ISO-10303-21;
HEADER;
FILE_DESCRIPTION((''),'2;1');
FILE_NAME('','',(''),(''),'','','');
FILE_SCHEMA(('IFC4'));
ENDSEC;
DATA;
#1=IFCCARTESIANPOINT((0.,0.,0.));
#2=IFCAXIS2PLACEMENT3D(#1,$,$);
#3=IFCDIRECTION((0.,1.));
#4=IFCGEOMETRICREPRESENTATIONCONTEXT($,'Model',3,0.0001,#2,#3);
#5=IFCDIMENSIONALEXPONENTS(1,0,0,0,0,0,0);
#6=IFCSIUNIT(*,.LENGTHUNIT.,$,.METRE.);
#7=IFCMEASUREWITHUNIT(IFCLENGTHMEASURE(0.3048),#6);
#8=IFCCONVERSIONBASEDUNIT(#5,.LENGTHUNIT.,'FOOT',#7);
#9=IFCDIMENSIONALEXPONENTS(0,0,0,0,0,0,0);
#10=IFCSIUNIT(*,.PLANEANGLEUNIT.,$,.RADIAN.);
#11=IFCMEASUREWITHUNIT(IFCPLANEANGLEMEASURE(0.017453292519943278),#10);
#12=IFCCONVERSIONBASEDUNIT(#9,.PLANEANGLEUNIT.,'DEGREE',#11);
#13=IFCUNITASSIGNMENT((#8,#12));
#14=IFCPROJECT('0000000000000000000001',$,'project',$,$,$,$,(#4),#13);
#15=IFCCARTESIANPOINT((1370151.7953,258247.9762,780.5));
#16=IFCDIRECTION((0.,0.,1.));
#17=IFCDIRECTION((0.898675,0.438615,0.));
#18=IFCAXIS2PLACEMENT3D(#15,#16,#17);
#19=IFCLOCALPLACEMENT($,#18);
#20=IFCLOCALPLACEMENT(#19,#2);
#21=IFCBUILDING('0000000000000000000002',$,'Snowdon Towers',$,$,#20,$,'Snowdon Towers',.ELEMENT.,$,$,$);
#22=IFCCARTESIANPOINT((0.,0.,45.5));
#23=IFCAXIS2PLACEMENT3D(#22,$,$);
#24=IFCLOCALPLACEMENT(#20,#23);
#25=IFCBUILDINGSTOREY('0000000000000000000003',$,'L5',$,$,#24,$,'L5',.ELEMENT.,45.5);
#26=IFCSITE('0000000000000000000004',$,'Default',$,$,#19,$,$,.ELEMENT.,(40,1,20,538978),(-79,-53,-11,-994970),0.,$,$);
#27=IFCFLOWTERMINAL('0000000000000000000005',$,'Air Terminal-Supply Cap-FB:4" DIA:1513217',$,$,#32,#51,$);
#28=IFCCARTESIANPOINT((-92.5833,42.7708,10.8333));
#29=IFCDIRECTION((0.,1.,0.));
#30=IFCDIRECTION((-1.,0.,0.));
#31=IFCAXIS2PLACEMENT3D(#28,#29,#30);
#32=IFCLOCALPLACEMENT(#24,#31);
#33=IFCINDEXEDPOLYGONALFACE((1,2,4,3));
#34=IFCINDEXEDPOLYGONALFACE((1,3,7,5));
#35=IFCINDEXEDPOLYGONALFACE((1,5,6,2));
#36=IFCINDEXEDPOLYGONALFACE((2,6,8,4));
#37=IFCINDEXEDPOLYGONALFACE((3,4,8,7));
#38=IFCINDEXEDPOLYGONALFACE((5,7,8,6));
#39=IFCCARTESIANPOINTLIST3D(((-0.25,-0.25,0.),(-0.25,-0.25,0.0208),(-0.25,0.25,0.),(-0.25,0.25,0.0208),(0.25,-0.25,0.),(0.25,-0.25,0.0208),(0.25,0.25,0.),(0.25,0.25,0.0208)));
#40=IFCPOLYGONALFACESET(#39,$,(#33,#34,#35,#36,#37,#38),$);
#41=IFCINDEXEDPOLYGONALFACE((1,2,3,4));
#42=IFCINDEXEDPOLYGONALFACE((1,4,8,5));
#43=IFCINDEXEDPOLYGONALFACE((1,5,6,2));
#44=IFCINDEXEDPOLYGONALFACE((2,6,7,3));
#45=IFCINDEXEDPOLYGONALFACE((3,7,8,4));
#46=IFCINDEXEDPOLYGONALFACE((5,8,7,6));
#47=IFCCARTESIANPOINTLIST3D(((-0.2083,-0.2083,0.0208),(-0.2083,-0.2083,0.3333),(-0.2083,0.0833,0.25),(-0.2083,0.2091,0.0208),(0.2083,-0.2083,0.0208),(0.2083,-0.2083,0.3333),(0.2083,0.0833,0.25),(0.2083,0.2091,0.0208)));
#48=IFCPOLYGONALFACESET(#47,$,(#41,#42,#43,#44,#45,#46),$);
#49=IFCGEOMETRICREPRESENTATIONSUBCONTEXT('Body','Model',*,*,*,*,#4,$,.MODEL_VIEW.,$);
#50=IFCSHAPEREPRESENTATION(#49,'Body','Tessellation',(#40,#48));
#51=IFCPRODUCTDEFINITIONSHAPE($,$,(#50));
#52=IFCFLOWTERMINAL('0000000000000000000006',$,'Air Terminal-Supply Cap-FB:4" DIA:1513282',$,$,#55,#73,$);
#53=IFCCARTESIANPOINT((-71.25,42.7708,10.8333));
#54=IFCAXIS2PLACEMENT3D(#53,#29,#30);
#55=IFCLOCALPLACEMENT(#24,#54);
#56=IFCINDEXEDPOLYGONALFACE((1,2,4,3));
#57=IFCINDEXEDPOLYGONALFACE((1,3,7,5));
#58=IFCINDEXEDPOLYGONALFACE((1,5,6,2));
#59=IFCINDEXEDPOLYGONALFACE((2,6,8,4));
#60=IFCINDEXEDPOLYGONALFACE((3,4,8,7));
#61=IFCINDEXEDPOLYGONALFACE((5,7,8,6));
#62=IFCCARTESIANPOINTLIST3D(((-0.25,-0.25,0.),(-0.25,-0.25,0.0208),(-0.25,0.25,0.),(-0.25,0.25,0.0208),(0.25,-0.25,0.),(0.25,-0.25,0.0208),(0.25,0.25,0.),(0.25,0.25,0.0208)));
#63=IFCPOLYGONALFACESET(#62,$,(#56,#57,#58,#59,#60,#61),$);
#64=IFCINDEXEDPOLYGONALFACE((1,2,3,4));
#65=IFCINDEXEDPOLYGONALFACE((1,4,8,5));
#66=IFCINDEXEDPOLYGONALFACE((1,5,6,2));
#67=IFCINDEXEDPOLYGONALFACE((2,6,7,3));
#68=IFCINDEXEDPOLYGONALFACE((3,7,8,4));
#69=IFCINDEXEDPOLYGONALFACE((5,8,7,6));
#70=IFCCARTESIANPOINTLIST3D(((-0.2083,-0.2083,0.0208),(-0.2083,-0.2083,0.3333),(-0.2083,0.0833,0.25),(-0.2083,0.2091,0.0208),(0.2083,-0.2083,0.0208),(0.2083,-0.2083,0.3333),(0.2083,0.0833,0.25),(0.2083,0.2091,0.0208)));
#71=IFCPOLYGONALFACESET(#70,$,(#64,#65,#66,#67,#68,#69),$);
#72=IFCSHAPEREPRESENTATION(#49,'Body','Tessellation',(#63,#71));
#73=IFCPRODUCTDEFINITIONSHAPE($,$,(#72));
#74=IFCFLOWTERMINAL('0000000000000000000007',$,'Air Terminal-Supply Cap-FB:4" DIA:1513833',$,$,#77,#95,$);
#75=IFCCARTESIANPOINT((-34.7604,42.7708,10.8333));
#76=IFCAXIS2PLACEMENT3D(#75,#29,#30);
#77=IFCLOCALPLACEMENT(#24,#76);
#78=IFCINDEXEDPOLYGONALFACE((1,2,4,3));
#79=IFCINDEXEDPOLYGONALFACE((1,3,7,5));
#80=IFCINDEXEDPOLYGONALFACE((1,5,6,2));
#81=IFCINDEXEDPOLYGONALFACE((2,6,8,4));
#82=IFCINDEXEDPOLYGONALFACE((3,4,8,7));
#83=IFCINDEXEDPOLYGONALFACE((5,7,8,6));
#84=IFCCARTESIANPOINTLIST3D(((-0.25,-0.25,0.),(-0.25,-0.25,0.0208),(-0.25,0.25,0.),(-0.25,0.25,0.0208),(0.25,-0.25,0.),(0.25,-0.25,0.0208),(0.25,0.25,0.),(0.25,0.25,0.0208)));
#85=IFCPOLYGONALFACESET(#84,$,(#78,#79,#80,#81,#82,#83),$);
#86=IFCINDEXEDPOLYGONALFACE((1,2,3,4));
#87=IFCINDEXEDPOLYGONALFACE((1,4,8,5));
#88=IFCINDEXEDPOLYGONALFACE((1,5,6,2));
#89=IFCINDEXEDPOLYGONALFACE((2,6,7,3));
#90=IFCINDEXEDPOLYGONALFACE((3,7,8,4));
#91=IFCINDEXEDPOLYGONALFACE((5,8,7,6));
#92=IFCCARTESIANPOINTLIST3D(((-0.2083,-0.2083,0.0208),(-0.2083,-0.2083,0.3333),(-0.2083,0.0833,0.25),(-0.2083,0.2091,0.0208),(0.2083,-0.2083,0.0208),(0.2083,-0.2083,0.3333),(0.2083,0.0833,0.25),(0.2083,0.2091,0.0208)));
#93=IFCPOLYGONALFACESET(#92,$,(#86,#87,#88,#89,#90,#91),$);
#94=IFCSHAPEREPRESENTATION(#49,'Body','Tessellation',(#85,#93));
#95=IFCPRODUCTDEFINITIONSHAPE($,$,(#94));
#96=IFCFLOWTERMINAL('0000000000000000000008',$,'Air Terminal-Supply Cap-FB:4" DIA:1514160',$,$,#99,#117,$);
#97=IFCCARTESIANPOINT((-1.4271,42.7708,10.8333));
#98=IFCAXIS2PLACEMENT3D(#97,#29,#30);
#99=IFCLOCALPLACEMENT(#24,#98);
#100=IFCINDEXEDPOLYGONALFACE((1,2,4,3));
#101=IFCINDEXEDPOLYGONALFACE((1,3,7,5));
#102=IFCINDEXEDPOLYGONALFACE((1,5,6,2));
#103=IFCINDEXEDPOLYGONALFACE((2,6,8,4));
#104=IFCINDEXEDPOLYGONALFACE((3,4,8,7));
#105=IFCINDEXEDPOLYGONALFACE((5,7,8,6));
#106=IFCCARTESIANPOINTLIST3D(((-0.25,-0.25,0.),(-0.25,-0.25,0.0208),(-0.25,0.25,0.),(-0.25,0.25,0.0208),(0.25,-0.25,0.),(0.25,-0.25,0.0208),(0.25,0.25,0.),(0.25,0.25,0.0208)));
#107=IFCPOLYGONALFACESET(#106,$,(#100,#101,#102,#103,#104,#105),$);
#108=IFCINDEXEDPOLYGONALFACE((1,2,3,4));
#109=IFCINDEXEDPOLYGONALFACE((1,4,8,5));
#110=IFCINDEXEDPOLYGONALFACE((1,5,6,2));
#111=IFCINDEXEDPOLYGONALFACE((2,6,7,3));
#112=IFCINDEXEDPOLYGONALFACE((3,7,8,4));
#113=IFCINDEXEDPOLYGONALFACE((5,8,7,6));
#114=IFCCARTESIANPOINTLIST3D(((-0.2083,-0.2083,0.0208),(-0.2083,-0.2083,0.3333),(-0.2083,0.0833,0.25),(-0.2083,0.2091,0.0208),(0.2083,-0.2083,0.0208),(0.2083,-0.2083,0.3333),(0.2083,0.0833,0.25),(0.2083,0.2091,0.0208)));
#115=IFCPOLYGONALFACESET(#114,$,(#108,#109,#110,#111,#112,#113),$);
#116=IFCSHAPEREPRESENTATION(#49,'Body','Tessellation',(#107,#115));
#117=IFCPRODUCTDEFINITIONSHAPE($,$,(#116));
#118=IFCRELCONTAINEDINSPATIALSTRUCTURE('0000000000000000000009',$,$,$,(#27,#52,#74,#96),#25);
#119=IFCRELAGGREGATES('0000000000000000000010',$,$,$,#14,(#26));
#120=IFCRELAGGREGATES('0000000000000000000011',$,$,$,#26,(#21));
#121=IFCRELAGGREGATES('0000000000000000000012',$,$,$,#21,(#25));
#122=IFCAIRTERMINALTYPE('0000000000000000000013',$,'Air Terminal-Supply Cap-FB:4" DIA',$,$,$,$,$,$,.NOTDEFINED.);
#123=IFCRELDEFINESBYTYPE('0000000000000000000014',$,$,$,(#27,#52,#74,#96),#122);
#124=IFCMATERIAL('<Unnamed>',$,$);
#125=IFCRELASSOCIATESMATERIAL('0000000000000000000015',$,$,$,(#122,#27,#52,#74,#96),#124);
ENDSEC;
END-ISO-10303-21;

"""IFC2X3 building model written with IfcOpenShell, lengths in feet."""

from ifc_helpers import new_model, entity, si_unit, converted_unit, direction, frame, origin, origin_2d_with_axis, place, context, subcontext, project, spatial, polyline, rectangle, outline, extrude, source, transform, mapped, material, type_object, type_shapes, element, save


model = new_model("IFC2X3")

# Units and contexts
model_context = context("Model", 3, precision=0.0001, world=origin(), true_north=direction((0.0, 1.0)))
body_context = subcontext(model_context, "Body", "Model", "MODEL_VIEW")
ifc_project = project(units=[converted_unit("LENGTHUNIT", "FOOT", entity("IfcLengthMeasure", 0.3048), si_unit("LENGTHUNIT", "METRE"), dimensions=[1, 0, 0, 0, 0, 0, 0]), converted_unit("PLANEANGLEUNIT", "DEGREE", entity("IfcPlaneAngleMeasure", 0.017453292519943278), si_unit("PLANEANGLEUNIT", "RADIAN"), dimensions=[0, 0, 0, 0, 0, 0, 0])], contexts=[model_context])

# Site, building, storey
site_placement = place(None, frame((1370151.7953, 258247.9762, 780.5), z_axis=(0.0, 0.0, 1.0), x_axis=(0.898675, 0.438615, 0.0)))
site = spatial("IfcSite", under=ifc_project, at=site_placement, Name="Default", CompositionType="ELEMENT", RefLatitude=(40, 1, 20, 538978), RefLongitude=(-79, -53, -11, -994970), RefElevation=0.0)
building_placement = place(site_placement, origin())
building = spatial("IfcBuilding", under=site, at=building_placement, Name="Snowdon Towers", LongName="Snowdon Towers", CompositionType="ELEMENT")
storey_placement = place(building_placement, frame((0.0, 0.0, 45.5)))
storey = spatial("IfcBuildingStorey", under=building, at=storey_placement, Name="L5", LongName="L5", CompositionType="ELEMENT", Elevation=45.5)

# Shared definitions
ifc_material = material(Name="<Unnamed>")

# Flow terminals
air_terminal_type = type_object("IfcAirTerminalType", Name="Air Terminal-Supply Cap-FB:4\" DIA", PredefinedType="NOTDEFINED", material=ifc_material)
shared_shape_1 = source(origin(), body_context, "Body", "SweptSolid", [
    extrude(rectangle(XDim=0.5, YDim=0.5, at=origin_2d_with_axis()), frame((0.0, 0.0, 0.0), z_axis=(0.0, 0.0, 1.0), x_axis=(-1.0, 0.0, 0.0)), (0.0, 0.0, 1.0), 0.0208),
    extrude(outline(polyline([(-0.1771, -0.1773), (0.1354, -0.1773), (0.1354, 0.2402), (-0.0938, 0.1144), (-0.1771, -0.1773)])), frame((-0.2083, -0.0311, 0.1562), z_axis=(1.0, 0.0, 0.0), x_axis=(0.0, 0.0, -1.0)), (0.0, 0.0, 1.0), 0.4167),
])
type_shapes(air_terminal_type, [shared_shape_1])
for number, where, z_axis, x_axis, name in (
    (1, (-92.5833, 42.7708, 10.8333), (0.0, 1.0, 0.0), (-1.0, 0.0, 0.0), "Air Terminal-Supply Cap-FB:4\" DIA:1513217"),
    (2, (-71.25, 42.7708, 10.8333), (0.0, 1.0, 0.0), (-1.0, 0.0, 0.0), "Air Terminal-Supply Cap-FB:4\" DIA:1513282"),
    (3, (-34.7604, 42.7708, 10.8333), (0.0, 1.0, 0.0), (-1.0, 0.0, 0.0), "Air Terminal-Supply Cap-FB:4\" DIA:1513833"),
    (4, (-1.4271, 42.7708, 10.8333), (0.0, 1.0, 0.0), (-1.0, 0.0, 0.0), "Air Terminal-Supply Cap-FB:4\" DIA:1514160"),
):
    element("IfcFlowTerminal", number, at=place(storey_placement, frame(where, z_axis=z_axis, x_axis=x_axis)), inside=storey, type_object=air_terminal_type, material=ifc_material, Name=name, context=body_context, shape_type="MappedRepresentation", body=[
        mapped(shared_shape_1, transform((0.0, 0.0, 0.0), scale=1.0)),
    ])

save(model, "model.ifc")
